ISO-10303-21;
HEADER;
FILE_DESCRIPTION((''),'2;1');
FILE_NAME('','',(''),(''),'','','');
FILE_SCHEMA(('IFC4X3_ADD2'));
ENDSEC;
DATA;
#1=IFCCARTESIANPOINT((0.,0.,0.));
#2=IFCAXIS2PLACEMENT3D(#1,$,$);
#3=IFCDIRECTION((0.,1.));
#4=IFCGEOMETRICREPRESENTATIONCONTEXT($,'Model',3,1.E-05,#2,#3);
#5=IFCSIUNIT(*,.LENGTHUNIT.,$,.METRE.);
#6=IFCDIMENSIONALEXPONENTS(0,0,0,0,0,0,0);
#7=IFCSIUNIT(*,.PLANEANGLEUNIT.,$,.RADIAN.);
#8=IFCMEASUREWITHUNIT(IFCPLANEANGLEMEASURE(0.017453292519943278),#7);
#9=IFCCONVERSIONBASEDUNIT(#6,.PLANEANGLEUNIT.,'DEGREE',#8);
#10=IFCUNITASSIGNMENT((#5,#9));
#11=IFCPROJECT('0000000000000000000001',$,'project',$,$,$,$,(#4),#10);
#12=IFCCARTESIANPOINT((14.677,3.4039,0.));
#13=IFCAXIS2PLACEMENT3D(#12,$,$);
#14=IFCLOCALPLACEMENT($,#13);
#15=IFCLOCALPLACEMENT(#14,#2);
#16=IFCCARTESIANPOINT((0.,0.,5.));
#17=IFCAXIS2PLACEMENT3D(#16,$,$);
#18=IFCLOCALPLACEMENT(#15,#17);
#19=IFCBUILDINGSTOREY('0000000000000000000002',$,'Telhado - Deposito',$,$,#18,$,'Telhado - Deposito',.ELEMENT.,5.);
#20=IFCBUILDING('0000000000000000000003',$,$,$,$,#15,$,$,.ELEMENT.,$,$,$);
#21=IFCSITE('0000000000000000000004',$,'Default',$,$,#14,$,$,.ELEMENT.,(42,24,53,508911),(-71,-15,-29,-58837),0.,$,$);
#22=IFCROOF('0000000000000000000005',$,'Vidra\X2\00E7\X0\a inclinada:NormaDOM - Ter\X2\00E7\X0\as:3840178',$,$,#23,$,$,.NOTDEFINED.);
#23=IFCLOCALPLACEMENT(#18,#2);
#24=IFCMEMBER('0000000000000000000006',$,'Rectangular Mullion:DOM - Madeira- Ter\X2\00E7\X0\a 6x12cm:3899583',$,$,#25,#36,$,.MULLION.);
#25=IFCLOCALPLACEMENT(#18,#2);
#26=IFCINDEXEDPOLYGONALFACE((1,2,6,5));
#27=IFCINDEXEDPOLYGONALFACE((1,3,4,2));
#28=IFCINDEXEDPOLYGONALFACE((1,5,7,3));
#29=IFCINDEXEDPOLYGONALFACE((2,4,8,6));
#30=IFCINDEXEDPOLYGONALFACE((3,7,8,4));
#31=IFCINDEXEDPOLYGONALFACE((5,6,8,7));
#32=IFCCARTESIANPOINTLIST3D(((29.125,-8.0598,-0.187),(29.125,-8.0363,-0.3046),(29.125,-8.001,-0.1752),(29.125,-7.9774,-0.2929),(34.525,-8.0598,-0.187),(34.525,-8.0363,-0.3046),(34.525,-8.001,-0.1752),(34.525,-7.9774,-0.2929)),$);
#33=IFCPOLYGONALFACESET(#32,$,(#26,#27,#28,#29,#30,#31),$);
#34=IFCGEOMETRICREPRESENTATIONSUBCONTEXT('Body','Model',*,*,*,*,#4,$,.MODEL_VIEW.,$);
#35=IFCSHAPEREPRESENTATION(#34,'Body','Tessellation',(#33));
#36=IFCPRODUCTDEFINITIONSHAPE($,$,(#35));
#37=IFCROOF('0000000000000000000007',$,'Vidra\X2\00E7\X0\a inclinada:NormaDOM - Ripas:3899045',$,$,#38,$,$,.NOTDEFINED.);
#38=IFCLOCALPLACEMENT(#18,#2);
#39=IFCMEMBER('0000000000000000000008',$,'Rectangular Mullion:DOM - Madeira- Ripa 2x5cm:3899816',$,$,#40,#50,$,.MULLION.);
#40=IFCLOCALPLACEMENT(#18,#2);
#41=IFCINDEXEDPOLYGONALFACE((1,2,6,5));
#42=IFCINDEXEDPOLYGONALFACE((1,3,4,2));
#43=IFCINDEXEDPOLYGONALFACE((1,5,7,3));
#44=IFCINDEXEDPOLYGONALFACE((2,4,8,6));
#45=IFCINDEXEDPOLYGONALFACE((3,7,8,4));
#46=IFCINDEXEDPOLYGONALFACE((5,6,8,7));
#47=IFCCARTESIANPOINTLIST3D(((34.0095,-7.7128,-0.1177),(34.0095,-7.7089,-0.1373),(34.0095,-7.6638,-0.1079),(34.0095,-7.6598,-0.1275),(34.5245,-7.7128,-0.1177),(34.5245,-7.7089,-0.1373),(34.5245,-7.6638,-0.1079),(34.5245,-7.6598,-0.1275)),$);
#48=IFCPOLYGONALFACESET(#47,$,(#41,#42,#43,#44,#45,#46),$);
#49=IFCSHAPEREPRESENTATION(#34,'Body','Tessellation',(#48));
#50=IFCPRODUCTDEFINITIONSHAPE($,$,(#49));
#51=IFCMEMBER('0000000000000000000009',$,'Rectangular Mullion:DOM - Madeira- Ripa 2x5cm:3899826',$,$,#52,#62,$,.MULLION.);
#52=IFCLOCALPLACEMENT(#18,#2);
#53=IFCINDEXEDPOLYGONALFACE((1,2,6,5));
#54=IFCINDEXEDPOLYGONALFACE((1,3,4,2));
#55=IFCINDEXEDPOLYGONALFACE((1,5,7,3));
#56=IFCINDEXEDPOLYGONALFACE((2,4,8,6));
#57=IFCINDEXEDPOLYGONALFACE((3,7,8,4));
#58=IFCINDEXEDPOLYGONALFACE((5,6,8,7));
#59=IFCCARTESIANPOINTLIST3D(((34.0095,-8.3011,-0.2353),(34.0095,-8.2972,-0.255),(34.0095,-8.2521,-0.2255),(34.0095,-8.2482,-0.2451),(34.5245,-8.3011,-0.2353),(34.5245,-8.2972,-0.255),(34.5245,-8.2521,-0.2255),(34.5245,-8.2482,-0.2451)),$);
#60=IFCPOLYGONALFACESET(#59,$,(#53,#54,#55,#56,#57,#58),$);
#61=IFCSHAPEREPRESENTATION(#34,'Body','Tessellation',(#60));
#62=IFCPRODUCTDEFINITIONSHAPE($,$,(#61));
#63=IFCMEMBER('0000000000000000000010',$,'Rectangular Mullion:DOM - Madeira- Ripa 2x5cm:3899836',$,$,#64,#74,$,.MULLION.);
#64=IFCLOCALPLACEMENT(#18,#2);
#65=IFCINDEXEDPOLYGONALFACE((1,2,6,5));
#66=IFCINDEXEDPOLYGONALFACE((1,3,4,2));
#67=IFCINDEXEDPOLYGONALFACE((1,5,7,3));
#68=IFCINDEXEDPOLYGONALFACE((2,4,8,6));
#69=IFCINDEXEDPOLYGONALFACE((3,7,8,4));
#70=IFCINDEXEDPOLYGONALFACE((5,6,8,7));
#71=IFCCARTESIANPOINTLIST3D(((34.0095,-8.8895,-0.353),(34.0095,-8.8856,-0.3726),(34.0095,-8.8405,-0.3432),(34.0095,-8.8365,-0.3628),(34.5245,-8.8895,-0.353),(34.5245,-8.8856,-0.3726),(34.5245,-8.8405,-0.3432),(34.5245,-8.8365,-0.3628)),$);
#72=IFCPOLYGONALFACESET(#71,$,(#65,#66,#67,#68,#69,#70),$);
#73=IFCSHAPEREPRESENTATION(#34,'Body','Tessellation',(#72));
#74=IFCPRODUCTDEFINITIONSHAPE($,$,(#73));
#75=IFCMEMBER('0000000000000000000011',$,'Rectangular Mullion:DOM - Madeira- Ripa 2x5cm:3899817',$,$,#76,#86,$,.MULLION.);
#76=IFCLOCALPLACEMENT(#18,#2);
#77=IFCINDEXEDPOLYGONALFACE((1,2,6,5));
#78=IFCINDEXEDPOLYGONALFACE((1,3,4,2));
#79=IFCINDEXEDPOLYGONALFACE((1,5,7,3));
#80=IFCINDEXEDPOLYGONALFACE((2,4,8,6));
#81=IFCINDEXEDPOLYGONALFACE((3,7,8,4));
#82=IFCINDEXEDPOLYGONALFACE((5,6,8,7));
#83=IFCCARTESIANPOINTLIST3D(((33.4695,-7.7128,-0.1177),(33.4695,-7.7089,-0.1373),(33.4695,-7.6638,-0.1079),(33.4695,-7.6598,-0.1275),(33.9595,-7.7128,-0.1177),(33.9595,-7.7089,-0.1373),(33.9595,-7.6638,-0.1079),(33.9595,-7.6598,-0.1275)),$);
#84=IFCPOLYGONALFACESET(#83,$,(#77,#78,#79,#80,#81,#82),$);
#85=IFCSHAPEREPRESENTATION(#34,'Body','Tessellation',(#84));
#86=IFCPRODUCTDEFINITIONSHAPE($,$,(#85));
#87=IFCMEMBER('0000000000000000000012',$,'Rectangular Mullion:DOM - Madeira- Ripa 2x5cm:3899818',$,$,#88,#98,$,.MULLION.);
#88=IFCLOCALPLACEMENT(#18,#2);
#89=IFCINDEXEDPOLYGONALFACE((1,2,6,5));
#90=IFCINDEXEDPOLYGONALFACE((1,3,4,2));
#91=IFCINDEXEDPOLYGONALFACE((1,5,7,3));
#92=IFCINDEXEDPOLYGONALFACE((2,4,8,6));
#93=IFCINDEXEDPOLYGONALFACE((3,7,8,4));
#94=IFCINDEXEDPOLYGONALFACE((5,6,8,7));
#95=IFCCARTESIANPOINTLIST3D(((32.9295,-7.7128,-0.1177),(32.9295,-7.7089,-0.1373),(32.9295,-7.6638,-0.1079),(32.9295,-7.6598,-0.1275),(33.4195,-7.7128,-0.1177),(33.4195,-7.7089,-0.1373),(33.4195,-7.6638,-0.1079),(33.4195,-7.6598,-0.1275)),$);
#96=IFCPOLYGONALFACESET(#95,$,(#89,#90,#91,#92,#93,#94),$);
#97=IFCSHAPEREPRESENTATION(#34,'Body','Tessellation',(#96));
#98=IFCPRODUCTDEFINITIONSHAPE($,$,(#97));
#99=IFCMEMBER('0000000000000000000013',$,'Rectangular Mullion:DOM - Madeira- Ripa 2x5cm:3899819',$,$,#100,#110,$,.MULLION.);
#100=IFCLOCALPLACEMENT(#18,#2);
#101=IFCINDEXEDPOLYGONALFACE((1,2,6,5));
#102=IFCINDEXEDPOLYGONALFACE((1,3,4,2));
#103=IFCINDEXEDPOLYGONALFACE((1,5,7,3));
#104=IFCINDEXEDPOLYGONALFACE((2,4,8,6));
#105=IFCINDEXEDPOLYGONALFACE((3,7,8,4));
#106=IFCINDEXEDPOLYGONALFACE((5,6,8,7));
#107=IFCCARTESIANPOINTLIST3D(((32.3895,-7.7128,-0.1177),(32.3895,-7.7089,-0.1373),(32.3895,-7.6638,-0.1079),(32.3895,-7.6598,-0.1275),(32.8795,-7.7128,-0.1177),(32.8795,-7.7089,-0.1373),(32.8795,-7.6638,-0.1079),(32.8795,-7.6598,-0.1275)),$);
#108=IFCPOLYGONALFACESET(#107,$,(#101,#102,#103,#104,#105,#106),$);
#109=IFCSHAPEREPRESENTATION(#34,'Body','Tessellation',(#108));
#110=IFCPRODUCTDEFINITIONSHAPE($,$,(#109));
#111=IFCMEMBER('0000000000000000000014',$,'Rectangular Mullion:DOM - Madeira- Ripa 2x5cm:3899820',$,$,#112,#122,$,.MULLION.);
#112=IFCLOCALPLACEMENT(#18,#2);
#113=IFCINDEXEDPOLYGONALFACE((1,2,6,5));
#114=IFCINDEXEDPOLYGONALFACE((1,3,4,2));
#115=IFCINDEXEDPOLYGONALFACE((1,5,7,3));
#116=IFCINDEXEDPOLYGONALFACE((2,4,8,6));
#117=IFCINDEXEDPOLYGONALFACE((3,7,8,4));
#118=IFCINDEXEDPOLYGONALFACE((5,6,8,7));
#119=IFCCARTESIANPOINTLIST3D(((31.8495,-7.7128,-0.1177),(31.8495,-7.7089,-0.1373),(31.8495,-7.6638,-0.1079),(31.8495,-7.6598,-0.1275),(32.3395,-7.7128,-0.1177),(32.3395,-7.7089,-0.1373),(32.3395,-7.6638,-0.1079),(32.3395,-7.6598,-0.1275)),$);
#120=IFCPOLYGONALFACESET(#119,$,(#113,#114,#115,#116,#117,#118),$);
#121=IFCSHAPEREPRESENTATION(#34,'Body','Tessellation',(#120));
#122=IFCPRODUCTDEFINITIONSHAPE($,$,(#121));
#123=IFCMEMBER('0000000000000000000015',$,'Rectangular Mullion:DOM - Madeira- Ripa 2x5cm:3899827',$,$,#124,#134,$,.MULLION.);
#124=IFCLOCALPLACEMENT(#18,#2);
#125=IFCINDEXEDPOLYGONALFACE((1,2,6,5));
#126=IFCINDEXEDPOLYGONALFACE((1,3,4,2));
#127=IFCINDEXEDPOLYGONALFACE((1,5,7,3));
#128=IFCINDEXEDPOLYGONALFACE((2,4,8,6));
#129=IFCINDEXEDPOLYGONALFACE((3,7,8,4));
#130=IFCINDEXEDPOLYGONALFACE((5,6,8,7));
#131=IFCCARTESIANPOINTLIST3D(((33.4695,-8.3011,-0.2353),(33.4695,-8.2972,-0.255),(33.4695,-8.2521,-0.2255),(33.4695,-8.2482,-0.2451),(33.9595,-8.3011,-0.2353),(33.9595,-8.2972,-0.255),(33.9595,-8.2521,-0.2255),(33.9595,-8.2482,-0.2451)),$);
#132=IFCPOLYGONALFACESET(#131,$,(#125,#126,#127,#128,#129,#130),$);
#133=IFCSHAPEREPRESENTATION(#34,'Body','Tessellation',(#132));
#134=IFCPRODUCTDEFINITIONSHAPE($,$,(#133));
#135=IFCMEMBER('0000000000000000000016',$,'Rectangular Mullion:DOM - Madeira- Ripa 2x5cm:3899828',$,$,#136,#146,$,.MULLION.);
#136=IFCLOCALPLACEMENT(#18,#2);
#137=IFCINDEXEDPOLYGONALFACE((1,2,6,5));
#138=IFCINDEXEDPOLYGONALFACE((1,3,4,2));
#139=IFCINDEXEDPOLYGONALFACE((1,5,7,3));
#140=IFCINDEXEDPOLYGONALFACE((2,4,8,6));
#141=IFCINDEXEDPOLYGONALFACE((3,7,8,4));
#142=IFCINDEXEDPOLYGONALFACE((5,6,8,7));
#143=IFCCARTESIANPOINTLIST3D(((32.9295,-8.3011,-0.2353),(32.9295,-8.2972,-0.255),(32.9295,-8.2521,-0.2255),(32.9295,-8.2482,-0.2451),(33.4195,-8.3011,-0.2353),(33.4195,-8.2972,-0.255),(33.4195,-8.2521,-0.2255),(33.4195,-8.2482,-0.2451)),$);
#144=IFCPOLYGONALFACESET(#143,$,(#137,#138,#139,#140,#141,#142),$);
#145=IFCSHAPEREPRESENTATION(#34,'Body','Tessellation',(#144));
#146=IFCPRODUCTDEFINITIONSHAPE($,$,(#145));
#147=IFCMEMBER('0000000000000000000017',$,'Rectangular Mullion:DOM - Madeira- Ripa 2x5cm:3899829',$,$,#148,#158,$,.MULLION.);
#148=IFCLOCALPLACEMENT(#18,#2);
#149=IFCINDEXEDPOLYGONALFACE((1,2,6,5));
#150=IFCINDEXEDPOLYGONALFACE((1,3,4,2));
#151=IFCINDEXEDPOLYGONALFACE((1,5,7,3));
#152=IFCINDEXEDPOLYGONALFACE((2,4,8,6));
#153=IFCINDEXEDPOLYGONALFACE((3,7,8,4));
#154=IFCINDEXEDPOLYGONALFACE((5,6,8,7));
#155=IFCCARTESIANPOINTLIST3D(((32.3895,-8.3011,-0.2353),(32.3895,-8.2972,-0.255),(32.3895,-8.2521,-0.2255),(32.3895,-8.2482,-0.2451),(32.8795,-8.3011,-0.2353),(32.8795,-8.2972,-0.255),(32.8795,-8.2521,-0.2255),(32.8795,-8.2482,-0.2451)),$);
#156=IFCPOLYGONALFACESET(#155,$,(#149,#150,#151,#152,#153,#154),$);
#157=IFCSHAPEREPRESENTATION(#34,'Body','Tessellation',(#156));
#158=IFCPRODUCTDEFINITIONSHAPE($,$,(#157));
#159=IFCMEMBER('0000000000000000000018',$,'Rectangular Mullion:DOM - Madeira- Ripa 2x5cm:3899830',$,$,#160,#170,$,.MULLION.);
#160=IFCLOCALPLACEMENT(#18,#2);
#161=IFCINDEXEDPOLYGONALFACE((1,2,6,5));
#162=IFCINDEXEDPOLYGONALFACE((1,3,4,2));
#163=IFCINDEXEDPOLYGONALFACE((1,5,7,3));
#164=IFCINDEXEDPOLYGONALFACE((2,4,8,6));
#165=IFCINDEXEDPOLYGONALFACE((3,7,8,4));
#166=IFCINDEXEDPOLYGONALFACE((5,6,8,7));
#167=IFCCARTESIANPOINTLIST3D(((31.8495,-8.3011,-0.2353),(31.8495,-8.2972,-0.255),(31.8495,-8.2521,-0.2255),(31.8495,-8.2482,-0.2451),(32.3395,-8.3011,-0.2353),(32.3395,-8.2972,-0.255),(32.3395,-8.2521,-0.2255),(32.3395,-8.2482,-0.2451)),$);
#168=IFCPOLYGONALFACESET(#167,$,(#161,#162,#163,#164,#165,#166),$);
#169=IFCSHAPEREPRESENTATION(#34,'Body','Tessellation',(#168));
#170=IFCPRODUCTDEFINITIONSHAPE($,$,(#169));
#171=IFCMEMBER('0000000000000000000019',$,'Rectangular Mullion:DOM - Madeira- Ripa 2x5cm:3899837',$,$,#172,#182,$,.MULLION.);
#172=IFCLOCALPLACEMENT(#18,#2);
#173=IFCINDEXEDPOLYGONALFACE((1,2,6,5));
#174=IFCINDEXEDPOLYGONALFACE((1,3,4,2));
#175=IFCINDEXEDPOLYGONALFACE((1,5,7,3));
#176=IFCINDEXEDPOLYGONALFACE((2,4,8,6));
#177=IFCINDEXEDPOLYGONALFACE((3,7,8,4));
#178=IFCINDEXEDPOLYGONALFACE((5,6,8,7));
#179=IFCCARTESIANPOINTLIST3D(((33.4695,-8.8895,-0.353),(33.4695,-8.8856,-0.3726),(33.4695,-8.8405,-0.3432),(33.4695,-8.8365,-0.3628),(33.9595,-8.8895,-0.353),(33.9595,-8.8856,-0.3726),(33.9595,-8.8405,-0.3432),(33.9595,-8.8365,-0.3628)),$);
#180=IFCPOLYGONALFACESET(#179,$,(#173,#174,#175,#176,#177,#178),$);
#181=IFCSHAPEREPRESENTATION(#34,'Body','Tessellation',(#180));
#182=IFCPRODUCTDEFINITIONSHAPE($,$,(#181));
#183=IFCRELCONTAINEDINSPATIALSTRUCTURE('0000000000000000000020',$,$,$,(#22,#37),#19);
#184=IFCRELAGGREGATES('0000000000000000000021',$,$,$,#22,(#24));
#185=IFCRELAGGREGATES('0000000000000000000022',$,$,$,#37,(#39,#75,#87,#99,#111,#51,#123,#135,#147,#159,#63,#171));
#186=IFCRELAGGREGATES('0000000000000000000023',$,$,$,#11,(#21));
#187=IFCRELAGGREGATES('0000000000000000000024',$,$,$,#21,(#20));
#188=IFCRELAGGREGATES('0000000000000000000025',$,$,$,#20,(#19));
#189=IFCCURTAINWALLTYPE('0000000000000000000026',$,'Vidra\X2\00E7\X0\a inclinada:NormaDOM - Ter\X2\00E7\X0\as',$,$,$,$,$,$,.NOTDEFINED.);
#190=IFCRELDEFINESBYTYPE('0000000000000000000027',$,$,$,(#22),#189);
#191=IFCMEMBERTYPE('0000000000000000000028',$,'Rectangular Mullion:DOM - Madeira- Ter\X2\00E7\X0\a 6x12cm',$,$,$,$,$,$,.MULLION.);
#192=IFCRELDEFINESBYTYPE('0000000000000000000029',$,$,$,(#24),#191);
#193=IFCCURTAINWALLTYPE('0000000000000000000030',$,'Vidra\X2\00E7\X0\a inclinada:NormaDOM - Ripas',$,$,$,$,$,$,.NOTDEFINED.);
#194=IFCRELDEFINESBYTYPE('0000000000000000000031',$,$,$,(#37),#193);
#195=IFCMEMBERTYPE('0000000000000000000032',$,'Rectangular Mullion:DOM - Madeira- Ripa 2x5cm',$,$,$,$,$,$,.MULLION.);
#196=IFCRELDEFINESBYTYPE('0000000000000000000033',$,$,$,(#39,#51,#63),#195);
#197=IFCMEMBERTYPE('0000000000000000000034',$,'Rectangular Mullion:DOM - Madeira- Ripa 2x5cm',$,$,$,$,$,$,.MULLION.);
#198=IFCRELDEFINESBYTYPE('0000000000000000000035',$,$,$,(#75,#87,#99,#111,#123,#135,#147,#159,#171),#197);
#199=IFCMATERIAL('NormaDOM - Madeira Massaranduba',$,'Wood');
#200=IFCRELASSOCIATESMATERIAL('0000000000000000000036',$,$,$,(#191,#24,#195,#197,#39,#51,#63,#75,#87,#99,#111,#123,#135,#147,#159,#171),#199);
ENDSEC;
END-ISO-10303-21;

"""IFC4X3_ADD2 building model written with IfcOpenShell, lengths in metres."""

from ifc_helpers import new_model, entity, si_unit, converted_unit, direction, frame, origin, origin_2d_with_axis, place, context, subcontext, project, spatial, rectangle, extrude, source, transform, mapped, material, material_profile, profile_set, profile_usage, type_object, type_shapes, element, aggregate, save


model = new_model("IFC4X3_ADD2")

# Units and contexts
model_context = context("Model", 3, precision=1e-05, world=origin(), true_north=direction((0.0, 1.0)))
body_context = subcontext(model_context, "Body", "Model", "MODEL_VIEW")
ifc_project = project(units=[si_unit("LENGTHUNIT", "METRE"), converted_unit("PLANEANGLEUNIT", "DEGREE", entity("IfcPlaneAngleMeasure", 0.017453292519943278), si_unit("PLANEANGLEUNIT", "RADIAN"), dimensions=[0, 0, 0, 0, 0, 0, 0])], contexts=[model_context])

# Site, building, storey
site_placement = place(None, frame((14.677, 3.4039, 0.0)))
site = spatial("IfcSite", under=ifc_project, at=site_placement, Name="Default", CompositionType="ELEMENT", RefLatitude=(42, 24, 53, 508911), RefLongitude=(-71, -15, -29, -58837), RefElevation=0.0)
building_placement = place(site_placement, origin())
building = spatial("IfcBuilding", under=site, at=building_placement, CompositionType="ELEMENT")
storey_placement = place(building_placement, frame((0.0, 0.0, 5.0)))
storey = spatial("IfcBuildingStorey", under=building, at=storey_placement, Name="Telhado - Deposito", LongName="Telhado - Deposito", CompositionType="ELEMENT", Elevation=5.0)

# Roof, member
curtain_wall_type_1 = type_object("IfcCurtainWallType", Name="Vidraça inclinada:NormaDOM - Terças", PredefinedType="NOTDEFINED")
roof_1_placement = place(storey_placement, frame((0.0, 0.0, -5.0)))
roof_1 = element("IfcRoof", 1, at=roof_1_placement, inside=storey, type_object=curtain_wall_type_1, Name="Vidraça inclinada:NormaDOM - Terças:3840178", PredefinedType="NOTDEFINED")
ifc_material = material(Name="NormaDOM - Madeira Massaranduba", Category="Wood")
ifc_material_profile_1 = material_profile(ifc_material, rectangle(XDim=0.06, YDim=0.12, at=origin_2d_with_axis()), Name="DOM - Madeira- Terça 6x12cm")
ifc_profile_set_1 = profile_set([ifc_material_profile_1], Name="DOM - Madeira- Terça 6x12cm")
ifc_profile_usage_1 = profile_usage(ifc_profile_set_1)
member_type_1 = type_object("IfcMemberType", Name="Rectangular Mullion:DOM - Madeira- Terça 6x12cm", PredefinedType="MULLION", material=ifc_profile_set_1)
shared_shape_1 = source(origin(), body_context, "Body", "SweptSolid", [
    extrude(rectangle(XDim=0.06, YDim=0.12, at=origin_2d_with_axis()), frame((0.0, 0.06, -5.4), z_axis=(0.0, 0.0, 1.0), x_axis=(-1.0, 0.0, 0.0)), (0.0, 0.0, 1.0), 5.4),
])
type_shapes(member_type_1, [shared_shape_1])
member_1_placement = place(roof_1_placement, frame((34.525, -8.0304, 4.8189), z_axis=(1.0, 0.0, 0.0), x_axis=(0.0, -0.980581, -0.196116)))
member_1 = element("IfcMember", 2, at=member_1_placement, type_object=member_type_1, material=ifc_profile_usage_1, Name="Rectangular Mullion:DOM - Madeira- Terça 6x12cm:3899583", PredefinedType="MULLION", context=body_context, shape_type="MappedRepresentation", body=[
    mapped(shared_shape_1, transform((0.0, 0.0, 0.0), scale=1.0)),
])
aggregate(roof_1, [member_1])

# Roof, members
curtain_wall_type_2 = type_object("IfcCurtainWallType", Name="Vidraça inclinada:NormaDOM - Ripas", PredefinedType="NOTDEFINED")
roof_2_placement = place(storey_placement, frame((0.0, 0.0, -5.0)))
roof_2 = element("IfcRoof", 3, at=roof_2_placement, inside=storey, type_object=curtain_wall_type_2, Name="Vidraça inclinada:NormaDOM - Ripas:3899045", PredefinedType="NOTDEFINED")
ifc_material_profile_2 = material_profile(ifc_material, rectangle(XDim=0.05, YDim=0.02, at=origin_2d_with_axis()), Name="DOM - Madeira- Ripa 2x5cm")
ifc_profile_set_2 = profile_set([ifc_material_profile_2], Name="DOM - Madeira- Ripa 2x5cm")
ifc_profile_usage_2 = profile_usage(ifc_profile_set_2)
member_type_2 = type_object("IfcMemberType", Name="Rectangular Mullion:DOM - Madeira- Ripa 2x5cm", PredefinedType="MULLION", material=ifc_profile_set_2)
shared_shape_2 = source(origin(), body_context, "Body", "SweptSolid", [
    extrude(rectangle(XDim=0.05, YDim=0.02, at=origin_2d_with_axis()), frame((0.025, 0.01, -0.515), z_axis=(0.0, 0.0, 1.0), x_axis=(-1.0, 0.0, 0.0)), (0.0, 0.0, 1.0), 0.515),
])
type_shapes(member_type_2, [shared_shape_2])
member_2_placement = place(roof_2_placement, frame((34.5245, -7.6638, 4.8921), z_axis=(1.0, 0.0, 0.0), x_axis=(0.0, -0.980581, -0.196116)))
member_2 = element("IfcMember", 4, at=member_2_placement, type_object=member_type_2, material=ifc_profile_usage_2, Name="Rectangular Mullion:DOM - Madeira- Ripa 2x5cm:3899816", PredefinedType="MULLION", context=body_context, shape_type="MappedRepresentation", body=[
    mapped(shared_shape_2, transform((0.0, 0.0, 0.0), scale=1.0)),
])
member_3_placement = place(roof_2_placement, frame((34.5245, -8.2521, 4.7745), z_axis=(1.0, 0.0, 0.0), x_axis=(0.0, -0.980581, -0.196116)))
member_3 = element("IfcMember", 5, at=member_3_placement, type_object=member_type_2, material=ifc_profile_usage_2, Name="Rectangular Mullion:DOM - Madeira- Ripa 2x5cm:3899826", PredefinedType="MULLION", context=body_context, shape_type="MappedRepresentation", body=[
    mapped(shared_shape_2, transform((0.0, 0.0, 0.0), scale=1.0)),
])
member_4_placement = place(roof_2_placement, frame((34.5245, -8.8405, 4.6568), z_axis=(1.0, 0.0, 0.0), x_axis=(0.0, -0.980581, -0.196116)))
member_4 = element("IfcMember", 6, at=member_4_placement, type_object=member_type_2, material=ifc_profile_usage_2, Name="Rectangular Mullion:DOM - Madeira- Ripa 2x5cm:3899836", PredefinedType="MULLION", context=body_context, shape_type="MappedRepresentation", body=[
    mapped(shared_shape_2, transform((0.0, 0.0, 0.0), scale=1.0)),
])
member_type_3 = type_object("IfcMemberType", Name="Rectangular Mullion:DOM - Madeira- Ripa 2x5cm", PredefinedType="MULLION", material=ifc_profile_set_2)
shared_shape_3 = source(origin(), body_context, "Body", "SweptSolid", [
    extrude(rectangle(XDim=0.05, YDim=0.02, at=origin_2d_with_axis()), frame((0.025, 0.01, -0.49), z_axis=(0.0, 0.0, 1.0), x_axis=(-1.0, 0.0, 0.0)), (0.0, 0.0, 1.0), 0.49),
])
type_shapes(member_type_3, [shared_shape_3])
member_5_placement = place(roof_2_placement, frame((33.9595, -7.6638, 4.8921), z_axis=(1.0, 0.0, 0.0), x_axis=(0.0, -0.980581, -0.196116)))
member_5 = element("IfcMember", 7, at=member_5_placement, type_object=member_type_3, material=ifc_profile_usage_2, Name="Rectangular Mullion:DOM - Madeira- Ripa 2x5cm:3899817", PredefinedType="MULLION", context=body_context, shape_type="MappedRepresentation", body=[
    mapped(shared_shape_3, transform((0.0, 0.0, 0.0), scale=1.0)),
])
member_6_placement = place(roof_2_placement, frame((33.4195, -7.6638, 4.8921), z_axis=(1.0, 0.0, 0.0), x_axis=(0.0, -0.980581, -0.196116)))
member_6 = element("IfcMember", 8, at=member_6_placement, type_object=member_type_3, material=ifc_profile_usage_2, Name="Rectangular Mullion:DOM - Madeira- Ripa 2x5cm:3899818", PredefinedType="MULLION", context=body_context, shape_type="MappedRepresentation", body=[
    mapped(shared_shape_3, transform((0.0, 0.0, 0.0), scale=1.0)),
])
member_7_placement = place(roof_2_placement, frame((32.8795, -7.6638, 4.8921), z_axis=(1.0, 0.0, 0.0), x_axis=(0.0, -0.980581, -0.196116)))
member_7 = element("IfcMember", 9, at=member_7_placement, type_object=member_type_3, material=ifc_profile_usage_2, Name="Rectangular Mullion:DOM - Madeira- Ripa 2x5cm:3899819", PredefinedType="MULLION", context=body_context, shape_type="MappedRepresentation", body=[
    mapped(shared_shape_3, transform((0.0, 0.0, 0.0), scale=1.0)),
])
member_8_placement = place(roof_2_placement, frame((32.3395, -7.6638, 4.8921), z_axis=(1.0, 0.0, 0.0), x_axis=(0.0, -0.980581, -0.196116)))
member_8 = element("IfcMember", 10, at=member_8_placement, type_object=member_type_3, material=ifc_profile_usage_2, Name="Rectangular Mullion:DOM - Madeira- Ripa 2x5cm:3899820", PredefinedType="MULLION", context=body_context, shape_type="MappedRepresentation", body=[
    mapped(shared_shape_3, transform((0.0, 0.0, 0.0), scale=1.0)),
])
member_9_placement = place(roof_2_placement, frame((33.9595, -8.2521, 4.7745), z_axis=(1.0, 0.0, 0.0), x_axis=(0.0, -0.980581, -0.196116)))
member_9 = element("IfcMember", 11, at=member_9_placement, type_object=member_type_3, material=ifc_profile_usage_2, Name="Rectangular Mullion:DOM - Madeira- Ripa 2x5cm:3899827", PredefinedType="MULLION", context=body_context, shape_type="MappedRepresentation", body=[
    mapped(shared_shape_3, transform((0.0, 0.0, 0.0), scale=1.0)),
])
member_10_placement = place(roof_2_placement, frame((33.4195, -8.2521, 4.7745), z_axis=(1.0, 0.0, 0.0), x_axis=(0.0, -0.980581, -0.196116)))
member_10 = element("IfcMember", 12, at=member_10_placement, type_object=member_type_3, material=ifc_profile_usage_2, Name="Rectangular Mullion:DOM - Madeira- Ripa 2x5cm:3899828", PredefinedType="MULLION", context=body_context, shape_type="MappedRepresentation", body=[
    mapped(shared_shape_3, transform((0.0, 0.0, 0.0), scale=1.0)),
])
member_11_placement = place(roof_2_placement, frame((32.8795, -8.2521, 4.7745), z_axis=(1.0, 0.0, 0.0), x_axis=(0.0, -0.980581, -0.196116)))
member_11 = element("IfcMember", 13, at=member_11_placement, type_object=member_type_3, material=ifc_profile_usage_2, Name="Rectangular Mullion:DOM - Madeira- Ripa 2x5cm:3899829", PredefinedType="MULLION", context=body_context, shape_type="MappedRepresentation", body=[
    mapped(shared_shape_3, transform((0.0, 0.0, 0.0), scale=1.0)),
])
member_12_placement = place(roof_2_placement, frame((32.3395, -8.2521, 4.7745), z_axis=(1.0, 0.0, 0.0), x_axis=(0.0, -0.980581, -0.196116)))
member_12 = element("IfcMember", 14, at=member_12_placement, type_object=member_type_3, material=ifc_profile_usage_2, Name="Rectangular Mullion:DOM - Madeira- Ripa 2x5cm:3899830", PredefinedType="MULLION", context=body_context, shape_type="MappedRepresentation", body=[
    mapped(shared_shape_3, transform((0.0, 0.0, 0.0), scale=1.0)),
])
member_13_placement = place(roof_2_placement, frame((33.9595, -8.8405, 4.6568), z_axis=(1.0, 0.0, 0.0), x_axis=(0.0, -0.980581, -0.196116)))
member_13 = element("IfcMember", 15, at=member_13_placement, type_object=member_type_3, material=ifc_profile_usage_2, Name="Rectangular Mullion:DOM - Madeira- Ripa 2x5cm:3899837", PredefinedType="MULLION", context=body_context, shape_type="MappedRepresentation", body=[
    mapped(shared_shape_3, transform((0.0, 0.0, 0.0), scale=1.0)),
])
aggregate(roof_2, [member_2, member_5, member_6, member_7, member_8, member_3, member_9, member_10, member_11, member_12, member_4, member_13])

save(model, "model.ifc")
